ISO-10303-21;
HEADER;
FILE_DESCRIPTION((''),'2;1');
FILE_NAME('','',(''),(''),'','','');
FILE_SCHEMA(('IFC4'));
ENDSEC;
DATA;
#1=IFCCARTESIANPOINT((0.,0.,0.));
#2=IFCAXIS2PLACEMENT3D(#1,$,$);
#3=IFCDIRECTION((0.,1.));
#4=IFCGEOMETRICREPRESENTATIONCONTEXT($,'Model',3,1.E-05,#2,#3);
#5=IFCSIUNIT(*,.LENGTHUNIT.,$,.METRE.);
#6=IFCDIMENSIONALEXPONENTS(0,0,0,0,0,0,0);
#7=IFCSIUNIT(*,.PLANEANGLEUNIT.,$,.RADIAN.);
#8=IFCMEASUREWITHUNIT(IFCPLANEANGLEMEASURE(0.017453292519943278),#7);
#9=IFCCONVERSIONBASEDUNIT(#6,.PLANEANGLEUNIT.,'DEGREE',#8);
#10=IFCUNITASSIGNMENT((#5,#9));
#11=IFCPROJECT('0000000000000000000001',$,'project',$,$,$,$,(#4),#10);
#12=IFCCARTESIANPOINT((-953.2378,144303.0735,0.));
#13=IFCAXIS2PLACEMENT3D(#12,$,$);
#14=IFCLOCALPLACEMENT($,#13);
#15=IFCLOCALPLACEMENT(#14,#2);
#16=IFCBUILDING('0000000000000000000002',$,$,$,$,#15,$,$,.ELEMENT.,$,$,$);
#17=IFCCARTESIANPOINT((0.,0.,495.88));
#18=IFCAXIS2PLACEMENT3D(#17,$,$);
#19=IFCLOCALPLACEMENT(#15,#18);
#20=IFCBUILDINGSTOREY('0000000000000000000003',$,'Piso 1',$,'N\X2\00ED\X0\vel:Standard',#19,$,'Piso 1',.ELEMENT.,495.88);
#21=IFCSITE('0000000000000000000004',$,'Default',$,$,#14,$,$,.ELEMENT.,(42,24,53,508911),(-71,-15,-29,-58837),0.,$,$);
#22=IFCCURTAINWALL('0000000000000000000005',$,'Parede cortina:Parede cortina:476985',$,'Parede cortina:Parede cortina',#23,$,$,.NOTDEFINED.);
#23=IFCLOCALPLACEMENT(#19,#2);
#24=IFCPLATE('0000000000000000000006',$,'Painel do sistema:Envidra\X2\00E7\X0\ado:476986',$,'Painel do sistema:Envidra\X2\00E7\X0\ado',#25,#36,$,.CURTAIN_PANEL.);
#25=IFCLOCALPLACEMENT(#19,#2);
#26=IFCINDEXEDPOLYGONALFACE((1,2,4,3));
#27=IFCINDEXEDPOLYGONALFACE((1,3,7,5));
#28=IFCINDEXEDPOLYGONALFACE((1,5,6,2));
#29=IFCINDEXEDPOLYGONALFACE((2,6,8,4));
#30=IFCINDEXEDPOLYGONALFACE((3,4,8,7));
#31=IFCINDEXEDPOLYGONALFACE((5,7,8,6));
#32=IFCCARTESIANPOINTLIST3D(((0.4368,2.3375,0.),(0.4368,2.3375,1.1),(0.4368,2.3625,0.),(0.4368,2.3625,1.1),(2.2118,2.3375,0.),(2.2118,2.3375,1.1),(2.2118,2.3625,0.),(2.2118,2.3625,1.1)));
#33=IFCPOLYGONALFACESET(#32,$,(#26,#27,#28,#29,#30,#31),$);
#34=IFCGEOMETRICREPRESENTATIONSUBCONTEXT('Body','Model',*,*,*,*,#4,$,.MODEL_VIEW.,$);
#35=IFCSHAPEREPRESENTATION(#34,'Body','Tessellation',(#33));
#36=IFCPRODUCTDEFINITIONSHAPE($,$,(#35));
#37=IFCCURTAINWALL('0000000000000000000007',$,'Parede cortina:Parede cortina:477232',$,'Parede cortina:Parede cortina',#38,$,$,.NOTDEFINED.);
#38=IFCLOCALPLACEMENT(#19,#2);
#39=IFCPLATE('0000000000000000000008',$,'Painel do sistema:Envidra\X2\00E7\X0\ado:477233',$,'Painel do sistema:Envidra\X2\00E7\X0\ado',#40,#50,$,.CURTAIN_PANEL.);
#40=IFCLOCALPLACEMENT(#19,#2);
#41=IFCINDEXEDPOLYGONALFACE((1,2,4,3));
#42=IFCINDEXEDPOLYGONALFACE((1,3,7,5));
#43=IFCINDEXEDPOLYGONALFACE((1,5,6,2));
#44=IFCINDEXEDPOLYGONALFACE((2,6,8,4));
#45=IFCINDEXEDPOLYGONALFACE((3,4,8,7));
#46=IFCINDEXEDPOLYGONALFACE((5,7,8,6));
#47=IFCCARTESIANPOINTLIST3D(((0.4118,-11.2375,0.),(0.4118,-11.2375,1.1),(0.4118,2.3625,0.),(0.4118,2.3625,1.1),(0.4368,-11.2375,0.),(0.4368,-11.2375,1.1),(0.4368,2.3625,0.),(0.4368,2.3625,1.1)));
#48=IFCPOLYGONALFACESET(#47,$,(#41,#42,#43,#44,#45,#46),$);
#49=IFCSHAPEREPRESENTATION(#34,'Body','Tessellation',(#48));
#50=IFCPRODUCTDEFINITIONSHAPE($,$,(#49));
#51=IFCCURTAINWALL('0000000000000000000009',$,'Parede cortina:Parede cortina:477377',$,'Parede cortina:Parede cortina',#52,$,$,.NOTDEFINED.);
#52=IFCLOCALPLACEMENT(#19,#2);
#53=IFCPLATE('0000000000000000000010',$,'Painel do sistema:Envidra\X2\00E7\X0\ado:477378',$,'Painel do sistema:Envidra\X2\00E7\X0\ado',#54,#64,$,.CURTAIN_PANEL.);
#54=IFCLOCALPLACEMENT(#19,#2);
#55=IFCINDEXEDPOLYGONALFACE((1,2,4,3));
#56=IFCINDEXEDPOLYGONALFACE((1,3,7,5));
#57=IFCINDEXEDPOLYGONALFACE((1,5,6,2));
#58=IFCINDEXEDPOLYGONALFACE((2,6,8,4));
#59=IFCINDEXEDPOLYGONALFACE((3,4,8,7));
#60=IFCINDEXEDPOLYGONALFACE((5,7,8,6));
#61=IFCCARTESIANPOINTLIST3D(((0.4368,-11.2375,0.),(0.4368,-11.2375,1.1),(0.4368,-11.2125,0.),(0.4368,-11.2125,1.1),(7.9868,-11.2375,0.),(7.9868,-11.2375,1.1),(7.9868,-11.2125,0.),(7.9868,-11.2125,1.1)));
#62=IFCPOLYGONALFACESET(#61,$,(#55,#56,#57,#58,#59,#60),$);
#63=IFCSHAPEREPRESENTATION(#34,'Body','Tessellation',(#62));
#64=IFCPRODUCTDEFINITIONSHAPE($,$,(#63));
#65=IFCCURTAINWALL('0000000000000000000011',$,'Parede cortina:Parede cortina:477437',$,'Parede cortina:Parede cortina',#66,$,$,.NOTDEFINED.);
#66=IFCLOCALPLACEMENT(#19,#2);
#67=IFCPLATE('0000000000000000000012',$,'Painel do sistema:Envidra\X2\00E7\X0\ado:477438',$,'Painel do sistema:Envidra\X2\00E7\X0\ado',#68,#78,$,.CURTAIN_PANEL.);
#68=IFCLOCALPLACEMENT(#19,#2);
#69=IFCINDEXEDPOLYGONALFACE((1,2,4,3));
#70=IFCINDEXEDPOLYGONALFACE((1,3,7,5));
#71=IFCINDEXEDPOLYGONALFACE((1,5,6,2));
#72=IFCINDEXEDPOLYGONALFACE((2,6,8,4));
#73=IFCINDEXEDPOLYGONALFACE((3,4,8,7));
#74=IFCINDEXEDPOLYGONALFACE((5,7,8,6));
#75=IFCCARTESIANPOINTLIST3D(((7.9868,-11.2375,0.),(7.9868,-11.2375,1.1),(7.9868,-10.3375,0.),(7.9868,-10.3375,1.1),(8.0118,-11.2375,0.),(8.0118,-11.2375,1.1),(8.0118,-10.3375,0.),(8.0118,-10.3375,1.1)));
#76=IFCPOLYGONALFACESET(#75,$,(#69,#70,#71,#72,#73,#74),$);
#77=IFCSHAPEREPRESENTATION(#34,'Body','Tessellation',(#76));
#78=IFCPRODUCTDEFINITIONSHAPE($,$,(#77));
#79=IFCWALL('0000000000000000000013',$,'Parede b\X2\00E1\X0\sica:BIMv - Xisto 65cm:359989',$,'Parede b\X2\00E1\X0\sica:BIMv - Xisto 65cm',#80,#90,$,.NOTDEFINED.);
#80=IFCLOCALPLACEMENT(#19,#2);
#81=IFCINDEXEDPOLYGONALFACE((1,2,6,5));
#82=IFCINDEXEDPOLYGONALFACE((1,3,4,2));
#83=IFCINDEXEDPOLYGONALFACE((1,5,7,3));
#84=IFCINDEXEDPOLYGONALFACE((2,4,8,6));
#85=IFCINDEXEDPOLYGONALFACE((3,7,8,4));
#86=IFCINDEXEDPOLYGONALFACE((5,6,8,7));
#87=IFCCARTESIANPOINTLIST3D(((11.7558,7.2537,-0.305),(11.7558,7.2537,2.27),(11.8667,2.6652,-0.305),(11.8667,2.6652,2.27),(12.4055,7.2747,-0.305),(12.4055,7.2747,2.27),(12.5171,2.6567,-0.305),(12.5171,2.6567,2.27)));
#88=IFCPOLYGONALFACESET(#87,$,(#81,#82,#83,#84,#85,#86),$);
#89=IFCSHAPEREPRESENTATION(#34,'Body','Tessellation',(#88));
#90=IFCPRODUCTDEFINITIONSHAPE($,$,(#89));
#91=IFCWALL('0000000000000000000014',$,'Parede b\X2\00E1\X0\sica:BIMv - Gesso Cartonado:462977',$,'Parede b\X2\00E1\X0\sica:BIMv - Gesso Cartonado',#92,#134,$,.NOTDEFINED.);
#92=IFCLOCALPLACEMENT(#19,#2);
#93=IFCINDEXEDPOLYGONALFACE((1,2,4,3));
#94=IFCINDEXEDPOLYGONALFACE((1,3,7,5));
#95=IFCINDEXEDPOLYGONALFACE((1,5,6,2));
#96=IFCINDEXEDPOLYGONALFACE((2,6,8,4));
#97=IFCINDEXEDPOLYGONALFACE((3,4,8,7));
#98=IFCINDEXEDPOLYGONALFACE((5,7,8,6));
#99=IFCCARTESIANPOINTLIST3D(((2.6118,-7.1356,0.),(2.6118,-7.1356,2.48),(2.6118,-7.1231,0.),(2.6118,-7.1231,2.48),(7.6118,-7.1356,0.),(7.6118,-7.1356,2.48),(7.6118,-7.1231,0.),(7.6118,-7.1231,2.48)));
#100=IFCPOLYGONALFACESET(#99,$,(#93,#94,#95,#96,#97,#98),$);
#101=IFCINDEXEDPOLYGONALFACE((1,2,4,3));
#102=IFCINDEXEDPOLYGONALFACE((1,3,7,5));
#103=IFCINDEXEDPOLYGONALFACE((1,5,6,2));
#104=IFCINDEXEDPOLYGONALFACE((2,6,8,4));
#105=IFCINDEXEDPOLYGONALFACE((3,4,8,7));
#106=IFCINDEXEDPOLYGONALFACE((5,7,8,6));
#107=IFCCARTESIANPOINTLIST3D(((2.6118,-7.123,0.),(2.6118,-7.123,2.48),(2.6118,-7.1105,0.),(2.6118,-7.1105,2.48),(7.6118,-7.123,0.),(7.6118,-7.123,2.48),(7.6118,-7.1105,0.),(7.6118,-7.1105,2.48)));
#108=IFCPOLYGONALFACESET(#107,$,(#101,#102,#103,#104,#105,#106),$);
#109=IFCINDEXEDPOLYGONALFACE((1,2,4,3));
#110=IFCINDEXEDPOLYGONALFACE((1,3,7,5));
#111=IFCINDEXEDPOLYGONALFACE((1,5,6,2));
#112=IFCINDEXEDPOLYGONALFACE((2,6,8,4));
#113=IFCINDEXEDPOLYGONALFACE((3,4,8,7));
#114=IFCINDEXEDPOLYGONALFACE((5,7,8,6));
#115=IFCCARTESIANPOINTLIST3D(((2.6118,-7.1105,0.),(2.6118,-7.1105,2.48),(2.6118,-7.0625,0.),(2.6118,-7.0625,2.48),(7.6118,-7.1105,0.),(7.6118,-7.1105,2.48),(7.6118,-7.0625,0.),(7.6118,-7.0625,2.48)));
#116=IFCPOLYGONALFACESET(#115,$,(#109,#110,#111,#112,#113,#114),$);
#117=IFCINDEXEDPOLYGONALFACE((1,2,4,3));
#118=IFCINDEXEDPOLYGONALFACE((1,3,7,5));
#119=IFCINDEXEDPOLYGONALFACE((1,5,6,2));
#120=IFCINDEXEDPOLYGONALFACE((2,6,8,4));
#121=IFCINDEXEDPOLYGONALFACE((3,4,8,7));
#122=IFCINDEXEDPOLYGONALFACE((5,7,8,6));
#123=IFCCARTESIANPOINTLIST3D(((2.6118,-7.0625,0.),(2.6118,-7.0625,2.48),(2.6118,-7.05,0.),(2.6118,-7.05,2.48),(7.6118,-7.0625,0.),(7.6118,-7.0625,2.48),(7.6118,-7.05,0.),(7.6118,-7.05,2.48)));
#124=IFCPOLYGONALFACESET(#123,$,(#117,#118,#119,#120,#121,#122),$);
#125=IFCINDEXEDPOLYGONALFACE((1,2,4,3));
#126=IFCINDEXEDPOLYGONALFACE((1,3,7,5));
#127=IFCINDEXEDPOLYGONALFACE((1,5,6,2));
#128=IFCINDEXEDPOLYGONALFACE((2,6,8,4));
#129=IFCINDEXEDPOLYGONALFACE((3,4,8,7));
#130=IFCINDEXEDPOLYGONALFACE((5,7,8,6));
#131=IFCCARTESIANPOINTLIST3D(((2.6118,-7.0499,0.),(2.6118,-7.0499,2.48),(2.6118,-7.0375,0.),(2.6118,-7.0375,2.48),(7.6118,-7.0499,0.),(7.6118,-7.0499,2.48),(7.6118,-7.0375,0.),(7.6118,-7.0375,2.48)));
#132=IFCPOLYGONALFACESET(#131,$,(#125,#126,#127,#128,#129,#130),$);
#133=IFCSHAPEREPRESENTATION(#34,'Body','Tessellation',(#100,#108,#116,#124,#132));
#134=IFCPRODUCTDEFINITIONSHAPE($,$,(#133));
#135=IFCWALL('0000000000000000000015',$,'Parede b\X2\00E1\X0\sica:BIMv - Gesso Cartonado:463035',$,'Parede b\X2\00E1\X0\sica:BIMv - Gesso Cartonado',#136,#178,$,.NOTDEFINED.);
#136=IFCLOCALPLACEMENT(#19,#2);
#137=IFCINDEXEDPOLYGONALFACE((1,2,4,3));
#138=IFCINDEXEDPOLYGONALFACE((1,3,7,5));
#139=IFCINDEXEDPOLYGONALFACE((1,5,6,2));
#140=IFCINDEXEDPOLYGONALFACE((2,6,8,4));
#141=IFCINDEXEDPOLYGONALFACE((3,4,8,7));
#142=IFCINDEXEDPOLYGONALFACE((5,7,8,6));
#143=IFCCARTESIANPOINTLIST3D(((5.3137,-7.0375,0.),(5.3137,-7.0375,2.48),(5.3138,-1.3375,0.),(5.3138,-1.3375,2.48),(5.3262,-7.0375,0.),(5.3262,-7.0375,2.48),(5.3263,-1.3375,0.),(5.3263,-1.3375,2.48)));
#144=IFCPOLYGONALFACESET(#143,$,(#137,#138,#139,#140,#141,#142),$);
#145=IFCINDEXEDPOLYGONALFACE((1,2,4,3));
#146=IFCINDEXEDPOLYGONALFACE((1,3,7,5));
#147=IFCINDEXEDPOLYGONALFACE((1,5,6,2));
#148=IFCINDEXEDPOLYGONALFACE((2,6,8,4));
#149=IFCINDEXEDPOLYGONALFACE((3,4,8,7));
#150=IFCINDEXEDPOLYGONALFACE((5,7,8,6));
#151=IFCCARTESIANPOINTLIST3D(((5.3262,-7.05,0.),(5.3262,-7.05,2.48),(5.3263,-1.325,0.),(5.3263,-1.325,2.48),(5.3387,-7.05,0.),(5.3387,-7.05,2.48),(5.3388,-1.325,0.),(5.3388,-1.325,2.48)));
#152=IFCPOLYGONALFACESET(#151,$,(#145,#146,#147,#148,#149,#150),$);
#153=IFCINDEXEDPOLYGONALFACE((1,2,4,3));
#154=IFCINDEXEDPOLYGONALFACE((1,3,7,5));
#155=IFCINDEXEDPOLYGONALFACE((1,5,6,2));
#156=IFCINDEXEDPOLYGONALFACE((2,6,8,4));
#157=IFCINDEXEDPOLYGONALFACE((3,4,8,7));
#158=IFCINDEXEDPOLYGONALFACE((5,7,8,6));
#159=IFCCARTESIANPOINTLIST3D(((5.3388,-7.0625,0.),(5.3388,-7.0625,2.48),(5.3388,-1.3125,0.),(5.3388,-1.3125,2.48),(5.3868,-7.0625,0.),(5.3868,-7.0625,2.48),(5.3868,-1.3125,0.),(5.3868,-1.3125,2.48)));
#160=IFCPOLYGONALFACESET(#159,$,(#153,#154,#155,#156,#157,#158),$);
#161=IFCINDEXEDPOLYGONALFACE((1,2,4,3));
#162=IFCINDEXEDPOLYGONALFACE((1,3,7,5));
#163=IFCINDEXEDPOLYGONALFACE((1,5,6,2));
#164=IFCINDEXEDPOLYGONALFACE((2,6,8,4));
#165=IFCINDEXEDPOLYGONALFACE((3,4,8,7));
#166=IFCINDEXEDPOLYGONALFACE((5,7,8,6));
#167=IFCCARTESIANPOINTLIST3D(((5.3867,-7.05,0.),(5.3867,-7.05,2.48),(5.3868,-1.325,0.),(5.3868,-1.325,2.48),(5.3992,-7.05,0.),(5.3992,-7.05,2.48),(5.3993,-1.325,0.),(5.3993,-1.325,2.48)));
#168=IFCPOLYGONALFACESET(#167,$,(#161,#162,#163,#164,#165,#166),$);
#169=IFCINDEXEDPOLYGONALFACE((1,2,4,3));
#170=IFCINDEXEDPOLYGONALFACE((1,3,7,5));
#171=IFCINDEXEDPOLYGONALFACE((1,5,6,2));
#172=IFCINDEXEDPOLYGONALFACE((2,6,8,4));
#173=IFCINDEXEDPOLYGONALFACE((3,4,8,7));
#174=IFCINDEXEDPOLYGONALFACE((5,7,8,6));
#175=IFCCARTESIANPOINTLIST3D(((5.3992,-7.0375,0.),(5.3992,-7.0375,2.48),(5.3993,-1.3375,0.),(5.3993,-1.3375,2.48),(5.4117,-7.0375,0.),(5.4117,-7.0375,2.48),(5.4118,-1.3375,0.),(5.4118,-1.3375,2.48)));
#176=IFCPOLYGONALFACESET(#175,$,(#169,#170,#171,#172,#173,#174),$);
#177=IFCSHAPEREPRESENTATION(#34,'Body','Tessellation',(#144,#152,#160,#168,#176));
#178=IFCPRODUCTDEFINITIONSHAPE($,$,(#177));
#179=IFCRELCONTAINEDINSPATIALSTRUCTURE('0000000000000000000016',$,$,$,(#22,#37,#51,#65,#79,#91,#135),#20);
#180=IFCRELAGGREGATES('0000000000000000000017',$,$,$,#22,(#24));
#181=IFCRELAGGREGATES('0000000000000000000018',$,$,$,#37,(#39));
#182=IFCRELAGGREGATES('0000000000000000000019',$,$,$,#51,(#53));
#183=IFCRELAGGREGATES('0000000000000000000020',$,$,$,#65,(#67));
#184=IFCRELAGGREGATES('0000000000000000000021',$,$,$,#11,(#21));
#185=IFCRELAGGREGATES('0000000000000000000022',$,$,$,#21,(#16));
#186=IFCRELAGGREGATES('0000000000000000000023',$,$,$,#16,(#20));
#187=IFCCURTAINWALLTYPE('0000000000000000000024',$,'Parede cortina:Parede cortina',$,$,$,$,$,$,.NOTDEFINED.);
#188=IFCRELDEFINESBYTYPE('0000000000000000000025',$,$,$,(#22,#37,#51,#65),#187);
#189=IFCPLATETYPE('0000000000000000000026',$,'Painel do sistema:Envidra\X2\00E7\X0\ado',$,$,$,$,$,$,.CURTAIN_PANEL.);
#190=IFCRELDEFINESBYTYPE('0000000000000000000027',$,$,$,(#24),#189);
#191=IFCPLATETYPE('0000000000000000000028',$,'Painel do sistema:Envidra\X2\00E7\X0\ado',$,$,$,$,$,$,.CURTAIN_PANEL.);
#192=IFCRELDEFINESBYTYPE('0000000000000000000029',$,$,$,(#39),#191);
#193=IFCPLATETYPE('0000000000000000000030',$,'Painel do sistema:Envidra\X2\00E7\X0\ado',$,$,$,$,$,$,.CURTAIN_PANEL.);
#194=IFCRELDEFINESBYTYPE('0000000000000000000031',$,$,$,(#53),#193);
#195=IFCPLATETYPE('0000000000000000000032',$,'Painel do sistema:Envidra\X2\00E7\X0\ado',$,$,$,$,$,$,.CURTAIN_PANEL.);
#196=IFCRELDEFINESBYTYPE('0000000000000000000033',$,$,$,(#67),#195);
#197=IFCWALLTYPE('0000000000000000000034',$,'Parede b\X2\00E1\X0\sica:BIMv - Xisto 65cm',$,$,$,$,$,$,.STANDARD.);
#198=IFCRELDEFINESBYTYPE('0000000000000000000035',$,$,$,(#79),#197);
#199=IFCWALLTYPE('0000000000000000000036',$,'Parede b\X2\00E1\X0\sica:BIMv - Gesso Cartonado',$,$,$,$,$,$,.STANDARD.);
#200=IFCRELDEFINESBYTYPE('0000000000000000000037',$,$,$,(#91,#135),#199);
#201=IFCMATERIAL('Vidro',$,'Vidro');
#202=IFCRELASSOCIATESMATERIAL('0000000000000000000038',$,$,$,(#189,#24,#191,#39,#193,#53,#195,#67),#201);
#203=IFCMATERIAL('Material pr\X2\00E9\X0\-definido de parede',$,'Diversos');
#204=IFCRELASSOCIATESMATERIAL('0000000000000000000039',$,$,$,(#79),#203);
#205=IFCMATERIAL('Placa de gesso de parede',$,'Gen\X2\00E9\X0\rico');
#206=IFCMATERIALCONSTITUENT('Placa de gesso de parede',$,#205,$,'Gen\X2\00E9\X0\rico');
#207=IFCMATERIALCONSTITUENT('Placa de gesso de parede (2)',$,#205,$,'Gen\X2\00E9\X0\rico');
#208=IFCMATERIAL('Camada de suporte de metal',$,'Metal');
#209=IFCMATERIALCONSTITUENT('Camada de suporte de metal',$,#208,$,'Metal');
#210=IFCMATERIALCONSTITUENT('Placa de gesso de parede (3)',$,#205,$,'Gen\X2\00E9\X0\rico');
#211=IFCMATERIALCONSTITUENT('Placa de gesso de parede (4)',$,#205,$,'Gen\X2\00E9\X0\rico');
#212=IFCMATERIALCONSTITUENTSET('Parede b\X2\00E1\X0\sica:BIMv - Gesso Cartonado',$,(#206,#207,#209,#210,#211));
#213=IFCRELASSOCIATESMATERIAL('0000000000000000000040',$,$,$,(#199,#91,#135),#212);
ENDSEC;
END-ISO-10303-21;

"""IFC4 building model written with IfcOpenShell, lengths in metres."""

from ifc_helpers import new_model, entity, si_unit, converted_unit, direction, frame, origin, place, context, subcontext, project, spatial, indexed_curve, outline, extrude, source, transform, mapped, material, constituent, constituent_set, type_object, type_shapes, element, aggregate, save


model = new_model("IFC4")

# Units and contexts
model_context = context("Model", 3, precision=1e-05, world=origin(), true_north=direction((0.0, 1.0)))
body_context = subcontext(model_context, "Body", "Model", "MODEL_VIEW")
ifc_project = project(units=[si_unit("LENGTHUNIT", "METRE"), converted_unit("PLANEANGLEUNIT", "DEGREE", entity("IfcPlaneAngleMeasure", 0.017453292519943278), si_unit("PLANEANGLEUNIT", "RADIAN"), dimensions=[0, 0, 0, 0, 0, 0, 0])], contexts=[model_context])

# Site, building, storey
site_placement = place(None, frame((-953.2378, 144303.0735, 0.0)))
site = spatial("IfcSite", under=ifc_project, at=site_placement, Name="Default", CompositionType="ELEMENT", RefLatitude=(42, 24, 53, 508911), RefLongitude=(-71, -15, -29, -58837), RefElevation=0.0)
building_placement = place(site_placement, origin())
building = spatial("IfcBuilding", under=site, at=building_placement, CompositionType="ELEMENT")
storey_placement = place(building_placement, frame((0.0, 0.0, 495.88)))
storey = spatial("IfcBuildingStorey", under=building, at=storey_placement, Name="Piso 1", ObjectType="Nível:Standard", LongName="Piso 1", CompositionType="ELEMENT", Elevation=495.88)

# Curtain walls, plates
curtain_wall_type = type_object("IfcCurtainWallType", Name="Parede cortina:Parede cortina", PredefinedType="NOTDEFINED")
placement_1 = place(storey_placement, frame((0.0, 0.0, -495.88)))
curtain_wall_1 = element("IfcCurtainWall", 1, at=placement_1, inside=storey, type_object=curtain_wall_type, Name="Parede cortina:Parede cortina:476985", ObjectType="Parede cortina:Parede cortina", PredefinedType="NOTDEFINED")
ifc_material_1 = material(Name="Vidro", Category="Vidro")
plate_type_1 = type_object("IfcPlateType", Name="Painel do sistema:Envidraçado", PredefinedType="CURTAIN_PANEL", material=ifc_material_1)
shared_shape_1 = source(origin(), body_context, "Body", "SweptSolid", [
    extrude(outline(indexed_curve([(-0.0125, -0.8875), (0.0125, -0.8875), (0.0125, 0.8875), (-0.0125, 0.8875), (-0.0125, -0.8875)], self_intersect=False)), frame((0.0, -0.037, 0.0), z_axis=(0.0, 0.0, 1.0), x_axis=(0.0, 1.0, 0.0)), (0.0, 0.0, 1.0), 1.1),
])
type_shapes(plate_type_1, [shared_shape_1])
plate_1_placement = place(placement_1, frame((1.3243, 2.313, 495.88), z_axis=(0.0, 0.0, 1.0), x_axis=(-1.0, 0.0, 0.0)))
plate_1 = element("IfcPlate", 2, at=plate_1_placement, type_object=plate_type_1, material=ifc_material_1, Name="Painel do sistema:Envidraçado:476986", ObjectType="Painel do sistema:Envidraçado", PredefinedType="CURTAIN_PANEL", context=body_context, shape_type="MappedRepresentation", body=[
    mapped(shared_shape_1, transform((0.0, 0.0, 0.0), scale=1.0)),
])
aggregate(curtain_wall_1, [plate_1])
curtain_wall_2 = element("IfcCurtainWall", 3, at=placement_1, inside=storey, type_object=curtain_wall_type, Name="Parede cortina:Parede cortina:477232", ObjectType="Parede cortina:Parede cortina", PredefinedType="NOTDEFINED")
plate_type_2 = type_object("IfcPlateType", Name="Painel do sistema:Envidraçado", PredefinedType="CURTAIN_PANEL", material=ifc_material_1)
shared_shape_2 = source(origin(), body_context, "Body", "SweptSolid", [
    extrude(outline(indexed_curve([(-0.0125, -6.8), (0.0125, -6.8), (0.0125, 6.8), (-0.0125, 6.8), (-0.0125, -6.8)], self_intersect=False)), frame((0.0, -0.037, 0.0), z_axis=(0.0, 0.0, 1.0), x_axis=(0.0, 1.0, 0.0)), (0.0, 0.0, 1.0), 1.1),
])
type_shapes(plate_type_2, [shared_shape_2])
plate_2_placement = place(placement_1, frame((0.4613, -4.4375, 495.88), z_axis=(0.0, 0.0, 1.0), x_axis=(0.0, -1.0, 0.0)))
plate_2 = element("IfcPlate", 4, at=plate_2_placement, type_object=plate_type_2, material=ifc_material_1, Name="Painel do sistema:Envidraçado:477233", ObjectType="Painel do sistema:Envidraçado", PredefinedType="CURTAIN_PANEL", context=body_context, shape_type="MappedRepresentation", body=[
    mapped(shared_shape_2, transform((0.0, 0.0, 0.0), scale=1.0)),
])
aggregate(curtain_wall_2, [plate_2])
curtain_wall_3 = element("IfcCurtainWall", 5, at=placement_1, inside=storey, type_object=curtain_wall_type, Name="Parede cortina:Parede cortina:477377", ObjectType="Parede cortina:Parede cortina", PredefinedType="NOTDEFINED")
plate_type_3 = type_object("IfcPlateType", Name="Painel do sistema:Envidraçado", PredefinedType="CURTAIN_PANEL", material=ifc_material_1)
shared_shape_3 = source(origin(), body_context, "Body", "SweptSolid", [
    extrude(outline(indexed_curve([(-0.0125, -3.775), (0.0125, -3.775), (0.0125, 3.775), (-0.0125, 3.775), (-0.0125, -3.775)], self_intersect=False)), frame((0.0, -0.037, 0.0), z_axis=(0.0, 0.0, 1.0), x_axis=(0.0, 1.0, 0.0)), (0.0, 0.0, 1.0), 1.1),
])
type_shapes(plate_type_3, [shared_shape_3])
plate_3_placement = place(placement_1, frame((4.2118, -11.188, 495.88)))
plate_3 = element("IfcPlate", 6, at=plate_3_placement, type_object=plate_type_3, material=ifc_material_1, Name="Painel do sistema:Envidraçado:477378", ObjectType="Painel do sistema:Envidraçado", PredefinedType="CURTAIN_PANEL", context=body_context, shape_type="MappedRepresentation", body=[
    mapped(shared_shape_3, transform((0.0, 0.0, 0.0), scale=1.0)),
])
aggregate(curtain_wall_3, [plate_3])
curtain_wall_4 = element("IfcCurtainWall", 7, at=placement_1, inside=storey, type_object=curtain_wall_type, Name="Parede cortina:Parede cortina:477437", ObjectType="Parede cortina:Parede cortina", PredefinedType="NOTDEFINED")
plate_type_4 = type_object("IfcPlateType", Name="Painel do sistema:Envidraçado", PredefinedType="CURTAIN_PANEL", material=ifc_material_1)
shared_shape_4 = source(origin(), body_context, "Body", "SweptSolid", [
    extrude(outline(indexed_curve([(-0.0125, -0.45), (0.0125, -0.45), (0.0125, 0.45), (-0.0125, 0.45), (-0.0125, -0.45)], self_intersect=False)), frame((0.0, -0.037, 0.0), z_axis=(0.0, 0.0, 1.0), x_axis=(0.0, 1.0, 0.0)), (0.0, 0.0, 1.0), 1.1),
])
type_shapes(plate_type_4, [shared_shape_4])
plate_4_placement = place(placement_1, frame((7.9623, -10.7875, 495.88), z_axis=(0.0, 0.0, 1.0), x_axis=(0.0, 1.0, 0.0)))
plate_4 = element("IfcPlate", 8, at=plate_4_placement, type_object=plate_type_4, material=ifc_material_1, Name="Painel do sistema:Envidraçado:477438", ObjectType="Painel do sistema:Envidraçado", PredefinedType="CURTAIN_PANEL", context=body_context, shape_type="MappedRepresentation", body=[
    mapped(shared_shape_4, transform((0.0, 0.0, 0.0), scale=1.0)),
])
aggregate(curtain_wall_4, [plate_4])

# Walls
ifc_material_2 = material(Name="Material pré-definido de parede", Category="Diversos")
wall_type_1 = type_object("IfcWallType", Name="Parede básica:BIMv - Xisto 65cm", PredefinedType="STANDARD")
wall_1_placement = place(storey_placement, frame((12.0806, 7.2668, -0.305), z_axis=(0.0, 0.0, 1.0), x_axis=(0.024156, -0.999708, 0.0)))
element("IfcWall", 9, at=wall_1_placement, inside=storey, type_object=wall_type_1, material=ifc_material_2, Name="Parede básica:BIMv - Xisto 65cm:359989", ObjectType="Parede básica:BIMv - Xisto 65cm", PredefinedType="NOTDEFINED", context=body_context, shape_type="SweptSolid", body=[
    extrude(outline(indexed_curve([(4.5951, -0.325), (4.6193, 0.325), (0.0, 0.325), (0.0053, -0.325), (4.5951, -0.325)], self_intersect=False)), origin(), (0.0, 0.0, 1.0), 2.575),
])
ifc_material_3 = material(Name="Placa de gesso de parede", Category="Genérico")
ifc_constituent_1 = constituent(ifc_material_3, Name="Placa de gesso de parede", Category="Genérico")
ifc_constituent_2 = constituent(ifc_material_3, Name="Placa de gesso de parede (2)", Category="Genérico")
ifc_material_4 = material(Name="Camada de suporte de metal", Category="Metal")
ifc_constituent_3 = constituent(ifc_material_4, Name="Camada de suporte de metal", Category="Metal")
ifc_constituent_4 = constituent(ifc_material_3, Name="Placa de gesso de parede (3)", Category="Genérico")
ifc_constituent_5 = constituent(ifc_material_3, Name="Placa de gesso de parede (4)", Category="Genérico")
ifc_constituent_set = constituent_set(constituents=[ifc_constituent_1, ifc_constituent_2, ifc_constituent_3, ifc_constituent_4, ifc_constituent_5], Name="Parede básica:BIMv - Gesso Cartonado")
wall_type_2 = type_object("IfcWallType", Name="Parede básica:BIMv - Gesso Cartonado", PredefinedType="STANDARD", material=ifc_constituent_set)
wall_2_placement = place(storey_placement, frame((2.6118, -7.0865, 0.0)))
element("IfcWall", 10, at=wall_2_placement, inside=storey, type_object=wall_type_2, material=ifc_constituent_set, Name="Parede básica:BIMv - Gesso Cartonado:462977", ObjectType="Parede básica:BIMv - Gesso Cartonado", PredefinedType="NOTDEFINED", context=body_context, shape_type="SweptSolid", body=[
    extrude(outline(indexed_curve([(-0.0063, -1.24), (0.0062, -1.24), (0.0062, 1.24), (-0.0063, 1.24), (-0.0063, -1.24)], self_intersect=False)), frame((0.0, -0.0428, 1.24), z_axis=(1.0, 0.0, 0.0), x_axis=(0.0, 1.0, 0.0)), (0.0, 0.0, 1.0), 5.0),
    extrude(outline(indexed_curve([(-1.24, -0.0063), (1.24, -0.0063), (1.24, 0.0062), (-1.24, 0.0062), (-1.24, -0.0063)], self_intersect=False)), frame((0.0, -0.0303, 1.24), z_axis=(1.0, 0.0, 0.0), x_axis=(0.0, 0.0, 1.0)), (0.0, 0.0, 1.0), 5.0),
    extrude(outline(indexed_curve([(-1.24, -0.024), (1.24, -0.024), (1.24, 0.024), (-1.24, 0.024), (-1.24, -0.024)], self_intersect=False)), frame((0.0, 0.0, 1.24), z_axis=(1.0, 0.0, 0.0), x_axis=(0.0, 0.0, 1.0)), (0.0, 0.0, 1.0), 5.0),
    extrude(outline(indexed_curve([(-1.24, -0.0062), (1.24, -0.0062), (1.24, 0.0063), (-1.24, 0.0063), (-1.24, -0.0062)], self_intersect=False)), frame((0.0, 0.0303, 1.24), z_axis=(1.0, 0.0, 0.0), x_axis=(0.0, 0.0, 1.0)), (0.0, 0.0, 1.0), 5.0),
    extrude(outline(indexed_curve([(-0.0062, -1.24), (0.0062, -1.24), (0.0062, 1.24), (-0.0062, 1.24), (-0.0062, -1.24)], self_intersect=False)), frame((0.0, 0.0428, 1.24), z_axis=(1.0, 0.0, 0.0), x_axis=(0.0, -1.0, 0.0)), (0.0, 0.0, 1.0), 5.0),
])
wall_3_placement = place(storey_placement, frame((5.3628, -1.3375, 0.0), z_axis=(0.0, 0.0, 1.0), x_axis=(0.0, -1.0, 0.0)))
element("IfcWall", 11, at=wall_3_placement, inside=storey, type_object=wall_type_2, material=ifc_constituent_set, Name="Parede básica:BIMv - Gesso Cartonado:463035", ObjectType="Parede básica:BIMv - Gesso Cartonado", PredefinedType="NOTDEFINED", context=body_context, shape_type="SweptSolid", body=[
    extrude(outline(indexed_curve([(-0.0063, -2.85), (0.0062, -2.85), (0.0063, 2.85), (-0.0062, 2.85), (-0.0063, -2.85)], self_intersect=False)), frame((2.85, -0.0428, 0.0), z_axis=(0.0, 0.0, 1.0), x_axis=(0.0, 1.0, 0.0)), (0.0, 0.0, 1.0), 2.48),
    extrude(outline(indexed_curve([(-2.8625, -0.0062), (2.8625, -0.0063), (2.8625, 0.0062), (-2.8625, 0.0063), (-2.8625, -0.0062)], self_intersect=False)), frame((2.85, -0.0303, 0.0)), (0.0, 0.0, 1.0), 2.48),
    extrude(outline(indexed_curve([(-2.875, -0.024), (2.875, -0.024), (2.875, 0.024), (-2.875, 0.024), (-2.875, -0.024)], self_intersect=False)), frame((2.85, 0.0, 0.0)), (0.0, 0.0, 1.0), 2.48),
    extrude(outline(indexed_curve([(-2.8625, -0.0062), (2.8625, -0.0063), (2.8625, 0.0062), (-2.8625, 0.0063), (-2.8625, -0.0062)], self_intersect=False)), frame((2.85, 0.0302, 0.0)), (0.0, 0.0, 1.0), 2.48),
    extrude(outline(indexed_curve([(-0.0063, -2.85), (0.0062, -2.85), (0.0063, 2.85), (-0.0062, 2.85), (-0.0063, -2.85)], self_intersect=False)), frame((2.85, 0.0427, 0.0), z_axis=(0.0, 0.0, 1.0), x_axis=(0.0, -1.0, 0.0)), (0.0, 0.0, 1.0), 2.48),
])

save(model, "model.ifc")
